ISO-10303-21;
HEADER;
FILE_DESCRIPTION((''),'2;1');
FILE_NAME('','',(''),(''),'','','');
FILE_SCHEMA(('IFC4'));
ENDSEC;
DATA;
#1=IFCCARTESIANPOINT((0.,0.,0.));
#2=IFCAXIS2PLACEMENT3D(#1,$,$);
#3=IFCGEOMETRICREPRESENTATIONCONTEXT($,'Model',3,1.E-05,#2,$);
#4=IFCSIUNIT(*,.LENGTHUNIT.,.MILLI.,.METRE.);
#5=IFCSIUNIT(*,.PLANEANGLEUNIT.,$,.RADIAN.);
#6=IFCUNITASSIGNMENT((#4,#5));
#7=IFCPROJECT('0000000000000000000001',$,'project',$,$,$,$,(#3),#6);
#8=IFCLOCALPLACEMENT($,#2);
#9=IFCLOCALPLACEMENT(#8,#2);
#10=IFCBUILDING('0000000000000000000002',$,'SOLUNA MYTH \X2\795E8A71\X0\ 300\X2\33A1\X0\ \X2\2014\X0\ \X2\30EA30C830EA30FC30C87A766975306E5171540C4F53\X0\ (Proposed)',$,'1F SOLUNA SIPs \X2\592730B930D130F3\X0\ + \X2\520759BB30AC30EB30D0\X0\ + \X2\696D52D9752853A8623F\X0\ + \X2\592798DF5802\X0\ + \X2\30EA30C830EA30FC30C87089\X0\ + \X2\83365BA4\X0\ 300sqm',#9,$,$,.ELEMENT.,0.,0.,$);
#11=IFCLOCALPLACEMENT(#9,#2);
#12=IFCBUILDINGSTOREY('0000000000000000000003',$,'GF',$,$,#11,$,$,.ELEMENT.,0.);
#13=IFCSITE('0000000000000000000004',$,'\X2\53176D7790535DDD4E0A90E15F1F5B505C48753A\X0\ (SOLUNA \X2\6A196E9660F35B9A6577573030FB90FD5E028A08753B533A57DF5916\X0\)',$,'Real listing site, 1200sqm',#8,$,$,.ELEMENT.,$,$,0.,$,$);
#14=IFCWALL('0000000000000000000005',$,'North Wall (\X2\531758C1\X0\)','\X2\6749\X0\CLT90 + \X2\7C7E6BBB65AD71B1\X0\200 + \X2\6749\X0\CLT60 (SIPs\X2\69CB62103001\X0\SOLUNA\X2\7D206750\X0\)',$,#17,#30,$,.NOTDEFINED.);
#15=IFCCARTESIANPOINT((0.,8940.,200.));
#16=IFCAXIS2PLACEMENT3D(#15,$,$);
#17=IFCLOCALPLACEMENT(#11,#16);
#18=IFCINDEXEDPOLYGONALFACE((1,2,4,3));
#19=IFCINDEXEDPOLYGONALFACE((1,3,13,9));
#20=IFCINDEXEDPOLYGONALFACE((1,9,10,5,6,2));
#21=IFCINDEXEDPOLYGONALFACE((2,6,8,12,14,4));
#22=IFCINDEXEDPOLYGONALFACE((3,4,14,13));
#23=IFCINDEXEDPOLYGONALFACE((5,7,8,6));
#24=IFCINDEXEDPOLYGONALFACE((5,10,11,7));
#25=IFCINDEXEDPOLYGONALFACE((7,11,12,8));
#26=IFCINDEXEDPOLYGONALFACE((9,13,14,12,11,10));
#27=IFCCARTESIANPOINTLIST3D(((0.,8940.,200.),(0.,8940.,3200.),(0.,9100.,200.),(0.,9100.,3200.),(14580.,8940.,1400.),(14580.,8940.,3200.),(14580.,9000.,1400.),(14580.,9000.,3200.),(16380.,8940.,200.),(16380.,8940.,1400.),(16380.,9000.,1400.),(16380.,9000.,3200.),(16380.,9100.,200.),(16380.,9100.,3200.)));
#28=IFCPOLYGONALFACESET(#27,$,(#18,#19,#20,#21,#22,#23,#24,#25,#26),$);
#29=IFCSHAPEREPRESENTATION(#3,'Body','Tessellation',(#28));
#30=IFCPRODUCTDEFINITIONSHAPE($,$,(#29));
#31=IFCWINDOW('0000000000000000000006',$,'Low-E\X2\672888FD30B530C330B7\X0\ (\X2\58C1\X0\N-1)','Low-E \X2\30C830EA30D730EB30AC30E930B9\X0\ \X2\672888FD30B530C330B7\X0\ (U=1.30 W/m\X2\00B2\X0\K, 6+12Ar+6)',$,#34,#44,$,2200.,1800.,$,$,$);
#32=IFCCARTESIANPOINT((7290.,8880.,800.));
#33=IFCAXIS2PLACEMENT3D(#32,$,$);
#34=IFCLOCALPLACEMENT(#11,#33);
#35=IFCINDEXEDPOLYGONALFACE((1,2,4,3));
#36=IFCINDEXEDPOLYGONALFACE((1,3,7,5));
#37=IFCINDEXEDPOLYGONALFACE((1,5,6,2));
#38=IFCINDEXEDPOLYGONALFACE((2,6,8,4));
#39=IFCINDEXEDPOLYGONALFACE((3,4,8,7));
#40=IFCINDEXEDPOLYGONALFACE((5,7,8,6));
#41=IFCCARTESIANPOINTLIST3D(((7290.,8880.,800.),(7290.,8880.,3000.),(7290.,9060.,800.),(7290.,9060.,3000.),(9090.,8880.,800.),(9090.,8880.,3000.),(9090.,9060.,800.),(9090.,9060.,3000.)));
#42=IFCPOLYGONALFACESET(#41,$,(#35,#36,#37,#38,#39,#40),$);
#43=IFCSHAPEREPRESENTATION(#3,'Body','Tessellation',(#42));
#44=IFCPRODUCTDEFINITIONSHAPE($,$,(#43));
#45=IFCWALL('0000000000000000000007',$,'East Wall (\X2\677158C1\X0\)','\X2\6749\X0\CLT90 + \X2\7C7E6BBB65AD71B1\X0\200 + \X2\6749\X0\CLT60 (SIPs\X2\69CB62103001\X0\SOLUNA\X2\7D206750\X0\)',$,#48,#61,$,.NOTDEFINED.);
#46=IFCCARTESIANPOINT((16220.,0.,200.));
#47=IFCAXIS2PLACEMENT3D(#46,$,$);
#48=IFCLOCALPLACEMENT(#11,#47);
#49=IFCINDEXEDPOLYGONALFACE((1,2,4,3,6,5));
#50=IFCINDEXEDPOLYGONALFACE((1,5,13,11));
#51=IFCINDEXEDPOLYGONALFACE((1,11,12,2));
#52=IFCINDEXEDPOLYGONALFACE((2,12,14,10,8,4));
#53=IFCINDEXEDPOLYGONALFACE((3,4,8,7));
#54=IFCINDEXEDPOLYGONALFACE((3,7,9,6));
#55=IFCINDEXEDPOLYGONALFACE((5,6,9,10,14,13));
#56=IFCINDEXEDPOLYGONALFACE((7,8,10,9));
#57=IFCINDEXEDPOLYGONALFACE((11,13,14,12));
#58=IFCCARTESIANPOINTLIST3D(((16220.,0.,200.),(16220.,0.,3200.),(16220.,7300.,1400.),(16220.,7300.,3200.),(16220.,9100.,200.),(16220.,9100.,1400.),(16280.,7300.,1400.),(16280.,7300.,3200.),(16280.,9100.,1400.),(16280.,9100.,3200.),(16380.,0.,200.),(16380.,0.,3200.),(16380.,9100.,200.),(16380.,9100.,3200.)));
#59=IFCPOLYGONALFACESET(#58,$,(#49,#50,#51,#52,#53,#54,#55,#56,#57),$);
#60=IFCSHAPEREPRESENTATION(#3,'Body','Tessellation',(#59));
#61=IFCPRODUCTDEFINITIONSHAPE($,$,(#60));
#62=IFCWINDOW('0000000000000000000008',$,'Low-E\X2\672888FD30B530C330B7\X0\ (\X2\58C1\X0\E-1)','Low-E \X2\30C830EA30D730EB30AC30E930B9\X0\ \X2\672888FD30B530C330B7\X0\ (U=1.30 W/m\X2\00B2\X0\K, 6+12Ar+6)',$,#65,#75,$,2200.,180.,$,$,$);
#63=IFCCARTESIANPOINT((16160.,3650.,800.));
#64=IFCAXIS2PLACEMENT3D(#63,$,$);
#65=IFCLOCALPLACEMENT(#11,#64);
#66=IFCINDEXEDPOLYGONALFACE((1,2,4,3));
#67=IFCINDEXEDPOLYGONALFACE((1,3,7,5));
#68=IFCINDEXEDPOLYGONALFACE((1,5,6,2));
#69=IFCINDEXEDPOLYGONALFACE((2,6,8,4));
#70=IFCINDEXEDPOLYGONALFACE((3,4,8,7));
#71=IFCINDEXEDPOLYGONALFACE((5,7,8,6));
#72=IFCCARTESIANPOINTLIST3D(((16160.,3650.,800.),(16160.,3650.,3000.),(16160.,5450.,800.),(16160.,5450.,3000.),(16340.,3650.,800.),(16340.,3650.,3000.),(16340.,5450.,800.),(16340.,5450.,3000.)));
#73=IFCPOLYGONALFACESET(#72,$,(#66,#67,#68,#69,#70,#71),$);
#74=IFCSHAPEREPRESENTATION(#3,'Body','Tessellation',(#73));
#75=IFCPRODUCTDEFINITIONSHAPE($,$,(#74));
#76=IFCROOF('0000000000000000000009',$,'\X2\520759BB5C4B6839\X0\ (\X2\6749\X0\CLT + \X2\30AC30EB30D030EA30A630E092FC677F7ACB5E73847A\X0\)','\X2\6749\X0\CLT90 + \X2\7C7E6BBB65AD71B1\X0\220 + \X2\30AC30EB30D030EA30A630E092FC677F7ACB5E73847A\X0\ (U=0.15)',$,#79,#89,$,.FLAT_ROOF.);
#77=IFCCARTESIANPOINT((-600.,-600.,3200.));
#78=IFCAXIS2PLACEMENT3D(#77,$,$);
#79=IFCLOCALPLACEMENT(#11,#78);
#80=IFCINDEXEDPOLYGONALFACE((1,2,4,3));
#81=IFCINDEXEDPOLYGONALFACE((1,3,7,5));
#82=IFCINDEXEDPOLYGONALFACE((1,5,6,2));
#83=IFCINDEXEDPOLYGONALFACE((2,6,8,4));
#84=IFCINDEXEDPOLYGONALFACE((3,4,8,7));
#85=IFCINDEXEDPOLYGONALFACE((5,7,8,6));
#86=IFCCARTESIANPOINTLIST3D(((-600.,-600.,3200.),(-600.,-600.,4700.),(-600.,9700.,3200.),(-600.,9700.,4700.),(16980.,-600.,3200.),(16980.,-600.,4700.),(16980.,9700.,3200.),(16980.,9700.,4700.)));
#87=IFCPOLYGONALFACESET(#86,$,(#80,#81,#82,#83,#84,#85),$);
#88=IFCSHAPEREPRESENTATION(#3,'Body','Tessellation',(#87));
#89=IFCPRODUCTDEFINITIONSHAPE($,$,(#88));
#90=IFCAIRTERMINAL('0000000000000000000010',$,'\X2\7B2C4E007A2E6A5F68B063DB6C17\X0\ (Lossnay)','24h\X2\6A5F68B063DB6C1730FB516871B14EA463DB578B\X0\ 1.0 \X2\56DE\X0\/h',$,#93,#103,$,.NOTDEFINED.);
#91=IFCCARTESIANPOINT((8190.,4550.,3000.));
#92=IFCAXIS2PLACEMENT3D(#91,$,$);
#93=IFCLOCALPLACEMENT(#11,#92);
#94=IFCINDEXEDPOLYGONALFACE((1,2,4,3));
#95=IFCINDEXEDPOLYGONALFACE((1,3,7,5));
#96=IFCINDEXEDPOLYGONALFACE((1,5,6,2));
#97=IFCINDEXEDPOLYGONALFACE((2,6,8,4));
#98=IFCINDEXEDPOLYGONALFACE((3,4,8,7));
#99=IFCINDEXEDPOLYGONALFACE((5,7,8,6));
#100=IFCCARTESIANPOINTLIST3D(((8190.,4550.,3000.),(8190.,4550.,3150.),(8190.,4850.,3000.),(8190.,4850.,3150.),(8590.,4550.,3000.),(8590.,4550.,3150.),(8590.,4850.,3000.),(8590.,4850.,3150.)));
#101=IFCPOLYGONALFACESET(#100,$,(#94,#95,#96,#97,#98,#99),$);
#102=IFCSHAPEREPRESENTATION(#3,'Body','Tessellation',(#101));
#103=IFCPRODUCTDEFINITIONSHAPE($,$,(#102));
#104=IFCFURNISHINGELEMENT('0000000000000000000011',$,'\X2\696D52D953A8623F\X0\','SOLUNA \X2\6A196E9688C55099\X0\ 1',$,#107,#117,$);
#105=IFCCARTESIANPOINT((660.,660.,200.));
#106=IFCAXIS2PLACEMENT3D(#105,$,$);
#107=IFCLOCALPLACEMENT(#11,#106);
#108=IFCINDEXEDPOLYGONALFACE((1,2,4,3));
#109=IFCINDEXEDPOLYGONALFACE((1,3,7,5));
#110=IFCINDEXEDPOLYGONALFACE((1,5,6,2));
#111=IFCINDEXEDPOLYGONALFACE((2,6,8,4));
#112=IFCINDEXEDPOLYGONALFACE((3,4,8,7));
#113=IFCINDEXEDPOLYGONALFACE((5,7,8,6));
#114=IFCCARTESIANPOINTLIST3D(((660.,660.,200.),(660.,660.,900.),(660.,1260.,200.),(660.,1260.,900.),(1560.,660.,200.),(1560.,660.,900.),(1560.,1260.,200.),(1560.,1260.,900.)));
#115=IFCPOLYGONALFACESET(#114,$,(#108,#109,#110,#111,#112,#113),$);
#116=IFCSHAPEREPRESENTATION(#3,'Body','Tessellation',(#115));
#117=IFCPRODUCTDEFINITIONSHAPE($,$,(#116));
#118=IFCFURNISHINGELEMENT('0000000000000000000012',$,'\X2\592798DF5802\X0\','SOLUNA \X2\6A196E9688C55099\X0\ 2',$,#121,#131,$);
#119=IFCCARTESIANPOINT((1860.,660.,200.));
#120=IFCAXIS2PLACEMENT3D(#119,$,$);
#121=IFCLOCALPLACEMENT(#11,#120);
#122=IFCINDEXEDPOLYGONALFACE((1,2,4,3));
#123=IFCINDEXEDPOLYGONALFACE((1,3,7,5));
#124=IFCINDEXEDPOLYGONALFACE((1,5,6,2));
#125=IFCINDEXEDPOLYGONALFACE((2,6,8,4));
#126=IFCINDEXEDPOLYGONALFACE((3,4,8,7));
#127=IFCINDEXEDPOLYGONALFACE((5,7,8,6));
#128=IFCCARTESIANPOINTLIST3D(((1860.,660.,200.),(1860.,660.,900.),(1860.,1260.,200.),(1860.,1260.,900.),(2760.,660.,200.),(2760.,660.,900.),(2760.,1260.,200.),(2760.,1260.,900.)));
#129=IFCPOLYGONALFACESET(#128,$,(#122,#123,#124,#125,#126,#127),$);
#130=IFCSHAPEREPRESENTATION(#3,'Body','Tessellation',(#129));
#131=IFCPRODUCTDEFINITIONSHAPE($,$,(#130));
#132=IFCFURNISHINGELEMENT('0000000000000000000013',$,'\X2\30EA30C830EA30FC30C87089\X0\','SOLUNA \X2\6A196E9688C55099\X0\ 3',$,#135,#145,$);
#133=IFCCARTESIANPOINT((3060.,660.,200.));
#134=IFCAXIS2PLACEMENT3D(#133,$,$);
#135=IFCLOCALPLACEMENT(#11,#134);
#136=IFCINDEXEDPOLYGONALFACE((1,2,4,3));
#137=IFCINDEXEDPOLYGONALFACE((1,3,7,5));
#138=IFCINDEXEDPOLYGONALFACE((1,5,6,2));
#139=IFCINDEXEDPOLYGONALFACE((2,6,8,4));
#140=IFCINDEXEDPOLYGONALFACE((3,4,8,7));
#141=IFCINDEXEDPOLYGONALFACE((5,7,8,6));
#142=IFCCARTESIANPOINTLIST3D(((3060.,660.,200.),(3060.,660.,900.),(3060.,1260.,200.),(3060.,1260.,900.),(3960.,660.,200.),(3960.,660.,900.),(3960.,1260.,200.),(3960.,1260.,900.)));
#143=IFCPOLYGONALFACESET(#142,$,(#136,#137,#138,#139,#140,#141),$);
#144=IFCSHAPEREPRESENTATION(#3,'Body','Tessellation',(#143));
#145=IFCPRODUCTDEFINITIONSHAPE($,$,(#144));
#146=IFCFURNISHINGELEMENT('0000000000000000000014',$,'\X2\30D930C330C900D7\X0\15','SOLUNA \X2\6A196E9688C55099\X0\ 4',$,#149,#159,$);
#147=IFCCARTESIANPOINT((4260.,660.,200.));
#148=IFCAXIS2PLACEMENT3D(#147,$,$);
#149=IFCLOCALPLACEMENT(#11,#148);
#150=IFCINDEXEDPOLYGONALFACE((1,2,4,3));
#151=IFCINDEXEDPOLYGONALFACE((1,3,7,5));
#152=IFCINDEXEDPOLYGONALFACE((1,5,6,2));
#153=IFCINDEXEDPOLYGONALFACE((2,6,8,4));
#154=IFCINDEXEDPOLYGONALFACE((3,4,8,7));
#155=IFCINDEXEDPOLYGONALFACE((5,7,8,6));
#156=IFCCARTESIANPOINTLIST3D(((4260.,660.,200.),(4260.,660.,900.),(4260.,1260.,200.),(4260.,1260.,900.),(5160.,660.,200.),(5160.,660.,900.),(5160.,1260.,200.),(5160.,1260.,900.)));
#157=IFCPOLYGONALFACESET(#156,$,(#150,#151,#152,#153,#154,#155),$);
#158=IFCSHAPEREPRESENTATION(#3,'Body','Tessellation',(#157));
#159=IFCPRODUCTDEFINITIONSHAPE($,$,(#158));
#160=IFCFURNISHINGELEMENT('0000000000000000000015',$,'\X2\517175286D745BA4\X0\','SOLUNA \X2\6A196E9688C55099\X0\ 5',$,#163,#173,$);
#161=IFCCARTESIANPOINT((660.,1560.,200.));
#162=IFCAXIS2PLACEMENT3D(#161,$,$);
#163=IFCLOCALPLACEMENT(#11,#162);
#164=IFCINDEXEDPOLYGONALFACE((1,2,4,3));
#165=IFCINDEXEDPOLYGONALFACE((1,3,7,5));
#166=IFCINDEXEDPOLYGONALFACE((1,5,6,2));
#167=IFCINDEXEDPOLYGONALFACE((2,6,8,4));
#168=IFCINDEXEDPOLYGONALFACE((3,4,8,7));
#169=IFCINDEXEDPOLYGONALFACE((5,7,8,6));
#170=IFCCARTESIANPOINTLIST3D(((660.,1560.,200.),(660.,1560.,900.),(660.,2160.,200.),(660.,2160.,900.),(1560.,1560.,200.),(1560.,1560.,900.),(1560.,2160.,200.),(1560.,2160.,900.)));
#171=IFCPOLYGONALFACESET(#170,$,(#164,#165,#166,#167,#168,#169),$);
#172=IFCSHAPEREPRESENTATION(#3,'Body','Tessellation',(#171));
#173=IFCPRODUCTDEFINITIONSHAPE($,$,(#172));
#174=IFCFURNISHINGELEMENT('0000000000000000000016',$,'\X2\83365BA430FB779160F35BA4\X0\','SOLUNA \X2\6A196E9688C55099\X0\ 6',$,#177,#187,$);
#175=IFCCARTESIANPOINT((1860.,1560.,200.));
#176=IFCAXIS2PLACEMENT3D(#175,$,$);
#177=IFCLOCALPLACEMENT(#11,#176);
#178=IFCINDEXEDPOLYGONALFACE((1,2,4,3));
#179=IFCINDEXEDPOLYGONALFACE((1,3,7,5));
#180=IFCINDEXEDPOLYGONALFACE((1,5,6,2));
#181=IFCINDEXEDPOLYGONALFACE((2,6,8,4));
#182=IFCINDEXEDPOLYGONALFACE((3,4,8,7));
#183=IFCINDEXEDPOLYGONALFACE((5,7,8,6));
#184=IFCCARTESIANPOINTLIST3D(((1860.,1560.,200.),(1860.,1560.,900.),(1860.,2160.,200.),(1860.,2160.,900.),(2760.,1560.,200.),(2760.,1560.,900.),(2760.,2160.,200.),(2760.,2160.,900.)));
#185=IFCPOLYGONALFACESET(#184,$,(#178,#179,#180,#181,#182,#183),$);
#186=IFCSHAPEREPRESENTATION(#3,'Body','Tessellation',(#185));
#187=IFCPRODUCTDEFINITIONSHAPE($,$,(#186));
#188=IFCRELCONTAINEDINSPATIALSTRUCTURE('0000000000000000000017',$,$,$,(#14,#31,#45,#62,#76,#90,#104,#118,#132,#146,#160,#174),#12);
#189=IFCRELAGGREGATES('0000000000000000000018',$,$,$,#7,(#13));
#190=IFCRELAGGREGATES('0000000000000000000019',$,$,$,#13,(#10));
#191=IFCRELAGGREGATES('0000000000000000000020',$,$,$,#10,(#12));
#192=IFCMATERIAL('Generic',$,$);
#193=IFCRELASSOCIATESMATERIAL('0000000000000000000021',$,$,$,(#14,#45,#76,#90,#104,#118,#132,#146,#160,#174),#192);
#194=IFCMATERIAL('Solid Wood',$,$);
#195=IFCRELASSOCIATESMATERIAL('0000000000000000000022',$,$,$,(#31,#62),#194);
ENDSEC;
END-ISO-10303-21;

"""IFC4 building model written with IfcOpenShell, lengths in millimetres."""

from ifc_helpers import new_model, si_unit, frame, frame_2d, origin, place, context, project, spatial, rectangle, extrude, material, element, fill, save


model = new_model("IFC4")

# Units and contexts
model_context = context("Model", 3, precision=1e-05, world=origin())
ifc_project = project(units=[si_unit("LENGTHUNIT", "METRE", prefix="MILLI"), si_unit("PLANEANGLEUNIT", "RADIAN")], contexts=[model_context])

# Site, building, storey
site_placement = place(None, origin())
site = spatial("IfcSite", under=ifc_project, at=site_placement, Name="北海道川上郡弟子屈町 (SOLUNA 標準想定敷地・都市計画区域外)", ObjectType="Real listing site, 1200sqm", CompositionType="ELEMENT", RefElevation=0.0)
building_placement = place(site_placement, origin())
building = spatial("IfcBuilding", under=site, at=building_placement, Name="SOLUNA MYTH 神話 300㎡ — リトリート究極の共同体 (Proposed)", ObjectType="1F SOLUNA SIPs 大スパン + 切妻ガルバ + 業務用厨房 + 大食堂 + リトリート炉 + 茶室 300sqm", CompositionType="ELEMENT", ElevationOfRefHeight=0.0, ElevationOfTerrain=0.0)
storey_placement = place(building_placement, origin())
storey = spatial("IfcBuildingStorey", under=building, at=storey_placement, Name="GF", CompositionType="ELEMENT", Elevation=0.0)

# Shared definitions
ifc_material_1 = material(Name="Generic")

# Shared definitions
ifc_material_2 = material(Name="Solid Wood")

# Walls, openings, windows
wall_1_placement = place(storey_placement, frame((0.0, 8940.0, 200.0)))
wall_1 = element("IfcWall", 1, at=wall_1_placement, inside=storey, material=ifc_material_1, Name="North Wall (北壁)", Description="杉CLT90 + 籾殻断熱200 + 杉CLT60 (SIPs構成、SOLUNA素材)", PredefinedType="NOTDEFINED", context=model_context, shape_type="SweptSolid", body=[
    extrude(rectangle(XDim=16380.0, YDim=160.0, at=frame_2d((8190.0, 80.0))), frame((0.0, 8940.0, 200.0)), (0.0, 0.0, 1.0), 3000.0),
])
opening_1_placement = place(storey_placement, frame((7290.0, 8880.0, 800.0)))
opening_1 = element("IfcOpeningElement", 2, at=opening_1_placement, cuts=wall_1, PredefinedType="NOTDEFINED", context=model_context, shape_type="SweptSolid", body=[
    extrude(rectangle(XDim=1800.0, YDim=180.0, at=frame_2d((900.0, 90.0))), frame((7290.0, 8880.0, 800.0)), (0.0, 0.0, 1.0), 2200.0),
])
window_1_placement = place(storey_placement, frame((7290.0, 8880.0, 800.0)))
window_1 = element("IfcWindow", 3, at=window_1_placement, inside=storey, material=ifc_material_2, Name="Low-E木製サッシ (壁N-1)", Description="Low-E トリプルガラス 木製サッシ (U=1.30 W/m²K, 6+12Ar+6)", OverallHeight=2200.0, OverallWidth=1800.0, context=model_context, shape_type="SweptSolid", body=[
    extrude(rectangle(XDim=1800.0, YDim=180.0, at=frame_2d((900.0, 90.0))), frame((7290.0, 8880.0, 800.0)), (0.0, 0.0, 1.0), 2200.0),
])
fill(opening_1, window_1)
wall_2_placement = place(storey_placement, frame((16220.0, 0.0, 200.0)))
wall_2 = element("IfcWall", 4, at=wall_2_placement, inside=storey, material=ifc_material_1, Name="East Wall (東壁)", Description="杉CLT90 + 籾殻断熱200 + 杉CLT60 (SIPs構成、SOLUNA素材)", PredefinedType="NOTDEFINED", context=model_context, shape_type="SweptSolid", body=[
    extrude(rectangle(XDim=160.0, YDim=9100.0, at=frame_2d((80.0, 4550.0))), frame((16220.0, 0.0, 200.0)), (0.0, 0.0, 1.0), 3000.0),
])
opening_2_placement = place(storey_placement, frame((16160.0, 3650.0, 800.0)))
opening_2 = element("IfcOpeningElement", 5, at=opening_2_placement, cuts=wall_2, PredefinedType="NOTDEFINED", context=model_context, shape_type="SweptSolid", body=[
    extrude(rectangle(XDim=180.0, YDim=1800.0, at=frame_2d((90.0, 900.0))), frame((16160.0, 3650.0, 800.0)), (0.0, 0.0, 1.0), 2200.0),
])
window_2_placement = place(storey_placement, frame((16160.0, 3650.0, 800.0)))
window_2 = element("IfcWindow", 6, at=window_2_placement, inside=storey, material=ifc_material_2, Name="Low-E木製サッシ (壁E-1)", Description="Low-E トリプルガラス 木製サッシ (U=1.30 W/m²K, 6+12Ar+6)", OverallHeight=2200.0, OverallWidth=180.0, context=model_context, shape_type="SweptSolid", body=[
    extrude(rectangle(XDim=180.0, YDim=1800.0, at=frame_2d((90.0, 900.0))), frame((16160.0, 3650.0, 800.0)), (0.0, 0.0, 1.0), 2200.0),
])
fill(opening_2, window_2)

# Roof
roof_placement = place(storey_placement, frame((-600.0, -600.0, 3200.0)))
element("IfcRoof", 7, at=roof_placement, inside=storey, material=ifc_material_1, Name="切妻屋根 (杉CLT + ガルバリウム鋼板立平葺)", Description="杉CLT90 + 籾殻断熱220 + ガルバリウム鋼板立平葺 (U=0.15)", PredefinedType="FLAT_ROOF", context=model_context, shape_type="SweptSolid", body=[
    extrude(rectangle(XDim=17580.0, YDim=10300.0, at=frame_2d((8790.0, 5150.0))), frame((-600.0, -600.0, 3200.0)), (0.0, 0.0, 1.0), 1500.0),
])

# Air terminal
air_terminal_placement = place(storey_placement, frame((8190.0, 4550.0, 3000.0)))
element("IfcAirTerminal", 8, at=air_terminal_placement, inside=storey, material=ifc_material_1, Name="第一種機械換気 (Lossnay)", Description="24h機械換気・全熱交換型 1.0 回/h", PredefinedType="NOTDEFINED", context=model_context, shape_type="SweptSolid", body=[
    extrude(rectangle(XDim=400.0, YDim=300.0, at=frame_2d((200.0, 150.0))), frame((8190.0, 4550.0, 3000.0)), (0.0, 0.0, 1.0), 150.0),
])

# Furnishing elements
furnishing_1_placement = place(storey_placement, frame((660.0, 660.0, 200.0)))
element("IfcFurnishingElement", 9, at=furnishing_1_placement, inside=storey, material=ifc_material_1, Name="業務厨房", Description="SOLUNA 標準装備 1", context=model_context, shape_type="SweptSolid", body=[
    extrude(rectangle(XDim=900.0, YDim=600.0, at=frame_2d((450.0, 300.0))), frame((660.0, 660.0, 200.0)), (0.0, 0.0, 1.0), 700.0),
])
furnishing_2_placement = place(storey_placement, frame((1860.0, 660.0, 200.0)))
element("IfcFurnishingElement", 10, at=furnishing_2_placement, inside=storey, material=ifc_material_1, Name="大食堂", Description="SOLUNA 標準装備 2", context=model_context, shape_type="SweptSolid", body=[
    extrude(rectangle(XDim=900.0, YDim=600.0, at=frame_2d((450.0, 300.0))), frame((1860.0, 660.0, 200.0)), (0.0, 0.0, 1.0), 700.0),
])
furnishing_3_placement = place(storey_placement, frame((3060.0, 660.0, 200.0)))
element("IfcFurnishingElement", 11, at=furnishing_3_placement, inside=storey, material=ifc_material_1, Name="リトリート炉", Description="SOLUNA 標準装備 3", context=model_context, shape_type="SweptSolid", body=[
    extrude(rectangle(XDim=900.0, YDim=600.0, at=frame_2d((450.0, 300.0))), frame((3060.0, 660.0, 200.0)), (0.0, 0.0, 1.0), 700.0),
])
furnishing_4_placement = place(storey_placement, frame((4260.0, 660.0, 200.0)))
element("IfcFurnishingElement", 12, at=furnishing_4_placement, inside=storey, material=ifc_material_1, Name="ベッド×15", Description="SOLUNA 標準装備 4", context=model_context, shape_type="SweptSolid", body=[
    extrude(rectangle(XDim=900.0, YDim=600.0, at=frame_2d((450.0, 300.0))), frame((4260.0, 660.0, 200.0)), (0.0, 0.0, 1.0), 700.0),
])
furnishing_5_placement = place(storey_placement, frame((660.0, 1560.0, 200.0)))
element("IfcFurnishingElement", 13, at=furnishing_5_placement, inside=storey, material=ifc_material_1, Name="共用浴室", Description="SOLUNA 標準装備 5", context=model_context, shape_type="SweptSolid", body=[
    extrude(rectangle(XDim=900.0, YDim=600.0, at=frame_2d((450.0, 300.0))), frame((660.0, 1560.0, 200.0)), (0.0, 0.0, 1.0), 700.0),
])
furnishing_6_placement = place(storey_placement, frame((1860.0, 1560.0, 200.0)))
element("IfcFurnishingElement", 14, at=furnishing_6_placement, inside=storey, material=ifc_material_1, Name="茶室・瞑想室", Description="SOLUNA 標準装備 6", context=model_context, shape_type="SweptSolid", body=[
    extrude(rectangle(XDim=900.0, YDim=600.0, at=frame_2d((450.0, 300.0))), frame((1860.0, 1560.0, 200.0)), (0.0, 0.0, 1.0), 700.0),
])

save(model, "model.ifc")
